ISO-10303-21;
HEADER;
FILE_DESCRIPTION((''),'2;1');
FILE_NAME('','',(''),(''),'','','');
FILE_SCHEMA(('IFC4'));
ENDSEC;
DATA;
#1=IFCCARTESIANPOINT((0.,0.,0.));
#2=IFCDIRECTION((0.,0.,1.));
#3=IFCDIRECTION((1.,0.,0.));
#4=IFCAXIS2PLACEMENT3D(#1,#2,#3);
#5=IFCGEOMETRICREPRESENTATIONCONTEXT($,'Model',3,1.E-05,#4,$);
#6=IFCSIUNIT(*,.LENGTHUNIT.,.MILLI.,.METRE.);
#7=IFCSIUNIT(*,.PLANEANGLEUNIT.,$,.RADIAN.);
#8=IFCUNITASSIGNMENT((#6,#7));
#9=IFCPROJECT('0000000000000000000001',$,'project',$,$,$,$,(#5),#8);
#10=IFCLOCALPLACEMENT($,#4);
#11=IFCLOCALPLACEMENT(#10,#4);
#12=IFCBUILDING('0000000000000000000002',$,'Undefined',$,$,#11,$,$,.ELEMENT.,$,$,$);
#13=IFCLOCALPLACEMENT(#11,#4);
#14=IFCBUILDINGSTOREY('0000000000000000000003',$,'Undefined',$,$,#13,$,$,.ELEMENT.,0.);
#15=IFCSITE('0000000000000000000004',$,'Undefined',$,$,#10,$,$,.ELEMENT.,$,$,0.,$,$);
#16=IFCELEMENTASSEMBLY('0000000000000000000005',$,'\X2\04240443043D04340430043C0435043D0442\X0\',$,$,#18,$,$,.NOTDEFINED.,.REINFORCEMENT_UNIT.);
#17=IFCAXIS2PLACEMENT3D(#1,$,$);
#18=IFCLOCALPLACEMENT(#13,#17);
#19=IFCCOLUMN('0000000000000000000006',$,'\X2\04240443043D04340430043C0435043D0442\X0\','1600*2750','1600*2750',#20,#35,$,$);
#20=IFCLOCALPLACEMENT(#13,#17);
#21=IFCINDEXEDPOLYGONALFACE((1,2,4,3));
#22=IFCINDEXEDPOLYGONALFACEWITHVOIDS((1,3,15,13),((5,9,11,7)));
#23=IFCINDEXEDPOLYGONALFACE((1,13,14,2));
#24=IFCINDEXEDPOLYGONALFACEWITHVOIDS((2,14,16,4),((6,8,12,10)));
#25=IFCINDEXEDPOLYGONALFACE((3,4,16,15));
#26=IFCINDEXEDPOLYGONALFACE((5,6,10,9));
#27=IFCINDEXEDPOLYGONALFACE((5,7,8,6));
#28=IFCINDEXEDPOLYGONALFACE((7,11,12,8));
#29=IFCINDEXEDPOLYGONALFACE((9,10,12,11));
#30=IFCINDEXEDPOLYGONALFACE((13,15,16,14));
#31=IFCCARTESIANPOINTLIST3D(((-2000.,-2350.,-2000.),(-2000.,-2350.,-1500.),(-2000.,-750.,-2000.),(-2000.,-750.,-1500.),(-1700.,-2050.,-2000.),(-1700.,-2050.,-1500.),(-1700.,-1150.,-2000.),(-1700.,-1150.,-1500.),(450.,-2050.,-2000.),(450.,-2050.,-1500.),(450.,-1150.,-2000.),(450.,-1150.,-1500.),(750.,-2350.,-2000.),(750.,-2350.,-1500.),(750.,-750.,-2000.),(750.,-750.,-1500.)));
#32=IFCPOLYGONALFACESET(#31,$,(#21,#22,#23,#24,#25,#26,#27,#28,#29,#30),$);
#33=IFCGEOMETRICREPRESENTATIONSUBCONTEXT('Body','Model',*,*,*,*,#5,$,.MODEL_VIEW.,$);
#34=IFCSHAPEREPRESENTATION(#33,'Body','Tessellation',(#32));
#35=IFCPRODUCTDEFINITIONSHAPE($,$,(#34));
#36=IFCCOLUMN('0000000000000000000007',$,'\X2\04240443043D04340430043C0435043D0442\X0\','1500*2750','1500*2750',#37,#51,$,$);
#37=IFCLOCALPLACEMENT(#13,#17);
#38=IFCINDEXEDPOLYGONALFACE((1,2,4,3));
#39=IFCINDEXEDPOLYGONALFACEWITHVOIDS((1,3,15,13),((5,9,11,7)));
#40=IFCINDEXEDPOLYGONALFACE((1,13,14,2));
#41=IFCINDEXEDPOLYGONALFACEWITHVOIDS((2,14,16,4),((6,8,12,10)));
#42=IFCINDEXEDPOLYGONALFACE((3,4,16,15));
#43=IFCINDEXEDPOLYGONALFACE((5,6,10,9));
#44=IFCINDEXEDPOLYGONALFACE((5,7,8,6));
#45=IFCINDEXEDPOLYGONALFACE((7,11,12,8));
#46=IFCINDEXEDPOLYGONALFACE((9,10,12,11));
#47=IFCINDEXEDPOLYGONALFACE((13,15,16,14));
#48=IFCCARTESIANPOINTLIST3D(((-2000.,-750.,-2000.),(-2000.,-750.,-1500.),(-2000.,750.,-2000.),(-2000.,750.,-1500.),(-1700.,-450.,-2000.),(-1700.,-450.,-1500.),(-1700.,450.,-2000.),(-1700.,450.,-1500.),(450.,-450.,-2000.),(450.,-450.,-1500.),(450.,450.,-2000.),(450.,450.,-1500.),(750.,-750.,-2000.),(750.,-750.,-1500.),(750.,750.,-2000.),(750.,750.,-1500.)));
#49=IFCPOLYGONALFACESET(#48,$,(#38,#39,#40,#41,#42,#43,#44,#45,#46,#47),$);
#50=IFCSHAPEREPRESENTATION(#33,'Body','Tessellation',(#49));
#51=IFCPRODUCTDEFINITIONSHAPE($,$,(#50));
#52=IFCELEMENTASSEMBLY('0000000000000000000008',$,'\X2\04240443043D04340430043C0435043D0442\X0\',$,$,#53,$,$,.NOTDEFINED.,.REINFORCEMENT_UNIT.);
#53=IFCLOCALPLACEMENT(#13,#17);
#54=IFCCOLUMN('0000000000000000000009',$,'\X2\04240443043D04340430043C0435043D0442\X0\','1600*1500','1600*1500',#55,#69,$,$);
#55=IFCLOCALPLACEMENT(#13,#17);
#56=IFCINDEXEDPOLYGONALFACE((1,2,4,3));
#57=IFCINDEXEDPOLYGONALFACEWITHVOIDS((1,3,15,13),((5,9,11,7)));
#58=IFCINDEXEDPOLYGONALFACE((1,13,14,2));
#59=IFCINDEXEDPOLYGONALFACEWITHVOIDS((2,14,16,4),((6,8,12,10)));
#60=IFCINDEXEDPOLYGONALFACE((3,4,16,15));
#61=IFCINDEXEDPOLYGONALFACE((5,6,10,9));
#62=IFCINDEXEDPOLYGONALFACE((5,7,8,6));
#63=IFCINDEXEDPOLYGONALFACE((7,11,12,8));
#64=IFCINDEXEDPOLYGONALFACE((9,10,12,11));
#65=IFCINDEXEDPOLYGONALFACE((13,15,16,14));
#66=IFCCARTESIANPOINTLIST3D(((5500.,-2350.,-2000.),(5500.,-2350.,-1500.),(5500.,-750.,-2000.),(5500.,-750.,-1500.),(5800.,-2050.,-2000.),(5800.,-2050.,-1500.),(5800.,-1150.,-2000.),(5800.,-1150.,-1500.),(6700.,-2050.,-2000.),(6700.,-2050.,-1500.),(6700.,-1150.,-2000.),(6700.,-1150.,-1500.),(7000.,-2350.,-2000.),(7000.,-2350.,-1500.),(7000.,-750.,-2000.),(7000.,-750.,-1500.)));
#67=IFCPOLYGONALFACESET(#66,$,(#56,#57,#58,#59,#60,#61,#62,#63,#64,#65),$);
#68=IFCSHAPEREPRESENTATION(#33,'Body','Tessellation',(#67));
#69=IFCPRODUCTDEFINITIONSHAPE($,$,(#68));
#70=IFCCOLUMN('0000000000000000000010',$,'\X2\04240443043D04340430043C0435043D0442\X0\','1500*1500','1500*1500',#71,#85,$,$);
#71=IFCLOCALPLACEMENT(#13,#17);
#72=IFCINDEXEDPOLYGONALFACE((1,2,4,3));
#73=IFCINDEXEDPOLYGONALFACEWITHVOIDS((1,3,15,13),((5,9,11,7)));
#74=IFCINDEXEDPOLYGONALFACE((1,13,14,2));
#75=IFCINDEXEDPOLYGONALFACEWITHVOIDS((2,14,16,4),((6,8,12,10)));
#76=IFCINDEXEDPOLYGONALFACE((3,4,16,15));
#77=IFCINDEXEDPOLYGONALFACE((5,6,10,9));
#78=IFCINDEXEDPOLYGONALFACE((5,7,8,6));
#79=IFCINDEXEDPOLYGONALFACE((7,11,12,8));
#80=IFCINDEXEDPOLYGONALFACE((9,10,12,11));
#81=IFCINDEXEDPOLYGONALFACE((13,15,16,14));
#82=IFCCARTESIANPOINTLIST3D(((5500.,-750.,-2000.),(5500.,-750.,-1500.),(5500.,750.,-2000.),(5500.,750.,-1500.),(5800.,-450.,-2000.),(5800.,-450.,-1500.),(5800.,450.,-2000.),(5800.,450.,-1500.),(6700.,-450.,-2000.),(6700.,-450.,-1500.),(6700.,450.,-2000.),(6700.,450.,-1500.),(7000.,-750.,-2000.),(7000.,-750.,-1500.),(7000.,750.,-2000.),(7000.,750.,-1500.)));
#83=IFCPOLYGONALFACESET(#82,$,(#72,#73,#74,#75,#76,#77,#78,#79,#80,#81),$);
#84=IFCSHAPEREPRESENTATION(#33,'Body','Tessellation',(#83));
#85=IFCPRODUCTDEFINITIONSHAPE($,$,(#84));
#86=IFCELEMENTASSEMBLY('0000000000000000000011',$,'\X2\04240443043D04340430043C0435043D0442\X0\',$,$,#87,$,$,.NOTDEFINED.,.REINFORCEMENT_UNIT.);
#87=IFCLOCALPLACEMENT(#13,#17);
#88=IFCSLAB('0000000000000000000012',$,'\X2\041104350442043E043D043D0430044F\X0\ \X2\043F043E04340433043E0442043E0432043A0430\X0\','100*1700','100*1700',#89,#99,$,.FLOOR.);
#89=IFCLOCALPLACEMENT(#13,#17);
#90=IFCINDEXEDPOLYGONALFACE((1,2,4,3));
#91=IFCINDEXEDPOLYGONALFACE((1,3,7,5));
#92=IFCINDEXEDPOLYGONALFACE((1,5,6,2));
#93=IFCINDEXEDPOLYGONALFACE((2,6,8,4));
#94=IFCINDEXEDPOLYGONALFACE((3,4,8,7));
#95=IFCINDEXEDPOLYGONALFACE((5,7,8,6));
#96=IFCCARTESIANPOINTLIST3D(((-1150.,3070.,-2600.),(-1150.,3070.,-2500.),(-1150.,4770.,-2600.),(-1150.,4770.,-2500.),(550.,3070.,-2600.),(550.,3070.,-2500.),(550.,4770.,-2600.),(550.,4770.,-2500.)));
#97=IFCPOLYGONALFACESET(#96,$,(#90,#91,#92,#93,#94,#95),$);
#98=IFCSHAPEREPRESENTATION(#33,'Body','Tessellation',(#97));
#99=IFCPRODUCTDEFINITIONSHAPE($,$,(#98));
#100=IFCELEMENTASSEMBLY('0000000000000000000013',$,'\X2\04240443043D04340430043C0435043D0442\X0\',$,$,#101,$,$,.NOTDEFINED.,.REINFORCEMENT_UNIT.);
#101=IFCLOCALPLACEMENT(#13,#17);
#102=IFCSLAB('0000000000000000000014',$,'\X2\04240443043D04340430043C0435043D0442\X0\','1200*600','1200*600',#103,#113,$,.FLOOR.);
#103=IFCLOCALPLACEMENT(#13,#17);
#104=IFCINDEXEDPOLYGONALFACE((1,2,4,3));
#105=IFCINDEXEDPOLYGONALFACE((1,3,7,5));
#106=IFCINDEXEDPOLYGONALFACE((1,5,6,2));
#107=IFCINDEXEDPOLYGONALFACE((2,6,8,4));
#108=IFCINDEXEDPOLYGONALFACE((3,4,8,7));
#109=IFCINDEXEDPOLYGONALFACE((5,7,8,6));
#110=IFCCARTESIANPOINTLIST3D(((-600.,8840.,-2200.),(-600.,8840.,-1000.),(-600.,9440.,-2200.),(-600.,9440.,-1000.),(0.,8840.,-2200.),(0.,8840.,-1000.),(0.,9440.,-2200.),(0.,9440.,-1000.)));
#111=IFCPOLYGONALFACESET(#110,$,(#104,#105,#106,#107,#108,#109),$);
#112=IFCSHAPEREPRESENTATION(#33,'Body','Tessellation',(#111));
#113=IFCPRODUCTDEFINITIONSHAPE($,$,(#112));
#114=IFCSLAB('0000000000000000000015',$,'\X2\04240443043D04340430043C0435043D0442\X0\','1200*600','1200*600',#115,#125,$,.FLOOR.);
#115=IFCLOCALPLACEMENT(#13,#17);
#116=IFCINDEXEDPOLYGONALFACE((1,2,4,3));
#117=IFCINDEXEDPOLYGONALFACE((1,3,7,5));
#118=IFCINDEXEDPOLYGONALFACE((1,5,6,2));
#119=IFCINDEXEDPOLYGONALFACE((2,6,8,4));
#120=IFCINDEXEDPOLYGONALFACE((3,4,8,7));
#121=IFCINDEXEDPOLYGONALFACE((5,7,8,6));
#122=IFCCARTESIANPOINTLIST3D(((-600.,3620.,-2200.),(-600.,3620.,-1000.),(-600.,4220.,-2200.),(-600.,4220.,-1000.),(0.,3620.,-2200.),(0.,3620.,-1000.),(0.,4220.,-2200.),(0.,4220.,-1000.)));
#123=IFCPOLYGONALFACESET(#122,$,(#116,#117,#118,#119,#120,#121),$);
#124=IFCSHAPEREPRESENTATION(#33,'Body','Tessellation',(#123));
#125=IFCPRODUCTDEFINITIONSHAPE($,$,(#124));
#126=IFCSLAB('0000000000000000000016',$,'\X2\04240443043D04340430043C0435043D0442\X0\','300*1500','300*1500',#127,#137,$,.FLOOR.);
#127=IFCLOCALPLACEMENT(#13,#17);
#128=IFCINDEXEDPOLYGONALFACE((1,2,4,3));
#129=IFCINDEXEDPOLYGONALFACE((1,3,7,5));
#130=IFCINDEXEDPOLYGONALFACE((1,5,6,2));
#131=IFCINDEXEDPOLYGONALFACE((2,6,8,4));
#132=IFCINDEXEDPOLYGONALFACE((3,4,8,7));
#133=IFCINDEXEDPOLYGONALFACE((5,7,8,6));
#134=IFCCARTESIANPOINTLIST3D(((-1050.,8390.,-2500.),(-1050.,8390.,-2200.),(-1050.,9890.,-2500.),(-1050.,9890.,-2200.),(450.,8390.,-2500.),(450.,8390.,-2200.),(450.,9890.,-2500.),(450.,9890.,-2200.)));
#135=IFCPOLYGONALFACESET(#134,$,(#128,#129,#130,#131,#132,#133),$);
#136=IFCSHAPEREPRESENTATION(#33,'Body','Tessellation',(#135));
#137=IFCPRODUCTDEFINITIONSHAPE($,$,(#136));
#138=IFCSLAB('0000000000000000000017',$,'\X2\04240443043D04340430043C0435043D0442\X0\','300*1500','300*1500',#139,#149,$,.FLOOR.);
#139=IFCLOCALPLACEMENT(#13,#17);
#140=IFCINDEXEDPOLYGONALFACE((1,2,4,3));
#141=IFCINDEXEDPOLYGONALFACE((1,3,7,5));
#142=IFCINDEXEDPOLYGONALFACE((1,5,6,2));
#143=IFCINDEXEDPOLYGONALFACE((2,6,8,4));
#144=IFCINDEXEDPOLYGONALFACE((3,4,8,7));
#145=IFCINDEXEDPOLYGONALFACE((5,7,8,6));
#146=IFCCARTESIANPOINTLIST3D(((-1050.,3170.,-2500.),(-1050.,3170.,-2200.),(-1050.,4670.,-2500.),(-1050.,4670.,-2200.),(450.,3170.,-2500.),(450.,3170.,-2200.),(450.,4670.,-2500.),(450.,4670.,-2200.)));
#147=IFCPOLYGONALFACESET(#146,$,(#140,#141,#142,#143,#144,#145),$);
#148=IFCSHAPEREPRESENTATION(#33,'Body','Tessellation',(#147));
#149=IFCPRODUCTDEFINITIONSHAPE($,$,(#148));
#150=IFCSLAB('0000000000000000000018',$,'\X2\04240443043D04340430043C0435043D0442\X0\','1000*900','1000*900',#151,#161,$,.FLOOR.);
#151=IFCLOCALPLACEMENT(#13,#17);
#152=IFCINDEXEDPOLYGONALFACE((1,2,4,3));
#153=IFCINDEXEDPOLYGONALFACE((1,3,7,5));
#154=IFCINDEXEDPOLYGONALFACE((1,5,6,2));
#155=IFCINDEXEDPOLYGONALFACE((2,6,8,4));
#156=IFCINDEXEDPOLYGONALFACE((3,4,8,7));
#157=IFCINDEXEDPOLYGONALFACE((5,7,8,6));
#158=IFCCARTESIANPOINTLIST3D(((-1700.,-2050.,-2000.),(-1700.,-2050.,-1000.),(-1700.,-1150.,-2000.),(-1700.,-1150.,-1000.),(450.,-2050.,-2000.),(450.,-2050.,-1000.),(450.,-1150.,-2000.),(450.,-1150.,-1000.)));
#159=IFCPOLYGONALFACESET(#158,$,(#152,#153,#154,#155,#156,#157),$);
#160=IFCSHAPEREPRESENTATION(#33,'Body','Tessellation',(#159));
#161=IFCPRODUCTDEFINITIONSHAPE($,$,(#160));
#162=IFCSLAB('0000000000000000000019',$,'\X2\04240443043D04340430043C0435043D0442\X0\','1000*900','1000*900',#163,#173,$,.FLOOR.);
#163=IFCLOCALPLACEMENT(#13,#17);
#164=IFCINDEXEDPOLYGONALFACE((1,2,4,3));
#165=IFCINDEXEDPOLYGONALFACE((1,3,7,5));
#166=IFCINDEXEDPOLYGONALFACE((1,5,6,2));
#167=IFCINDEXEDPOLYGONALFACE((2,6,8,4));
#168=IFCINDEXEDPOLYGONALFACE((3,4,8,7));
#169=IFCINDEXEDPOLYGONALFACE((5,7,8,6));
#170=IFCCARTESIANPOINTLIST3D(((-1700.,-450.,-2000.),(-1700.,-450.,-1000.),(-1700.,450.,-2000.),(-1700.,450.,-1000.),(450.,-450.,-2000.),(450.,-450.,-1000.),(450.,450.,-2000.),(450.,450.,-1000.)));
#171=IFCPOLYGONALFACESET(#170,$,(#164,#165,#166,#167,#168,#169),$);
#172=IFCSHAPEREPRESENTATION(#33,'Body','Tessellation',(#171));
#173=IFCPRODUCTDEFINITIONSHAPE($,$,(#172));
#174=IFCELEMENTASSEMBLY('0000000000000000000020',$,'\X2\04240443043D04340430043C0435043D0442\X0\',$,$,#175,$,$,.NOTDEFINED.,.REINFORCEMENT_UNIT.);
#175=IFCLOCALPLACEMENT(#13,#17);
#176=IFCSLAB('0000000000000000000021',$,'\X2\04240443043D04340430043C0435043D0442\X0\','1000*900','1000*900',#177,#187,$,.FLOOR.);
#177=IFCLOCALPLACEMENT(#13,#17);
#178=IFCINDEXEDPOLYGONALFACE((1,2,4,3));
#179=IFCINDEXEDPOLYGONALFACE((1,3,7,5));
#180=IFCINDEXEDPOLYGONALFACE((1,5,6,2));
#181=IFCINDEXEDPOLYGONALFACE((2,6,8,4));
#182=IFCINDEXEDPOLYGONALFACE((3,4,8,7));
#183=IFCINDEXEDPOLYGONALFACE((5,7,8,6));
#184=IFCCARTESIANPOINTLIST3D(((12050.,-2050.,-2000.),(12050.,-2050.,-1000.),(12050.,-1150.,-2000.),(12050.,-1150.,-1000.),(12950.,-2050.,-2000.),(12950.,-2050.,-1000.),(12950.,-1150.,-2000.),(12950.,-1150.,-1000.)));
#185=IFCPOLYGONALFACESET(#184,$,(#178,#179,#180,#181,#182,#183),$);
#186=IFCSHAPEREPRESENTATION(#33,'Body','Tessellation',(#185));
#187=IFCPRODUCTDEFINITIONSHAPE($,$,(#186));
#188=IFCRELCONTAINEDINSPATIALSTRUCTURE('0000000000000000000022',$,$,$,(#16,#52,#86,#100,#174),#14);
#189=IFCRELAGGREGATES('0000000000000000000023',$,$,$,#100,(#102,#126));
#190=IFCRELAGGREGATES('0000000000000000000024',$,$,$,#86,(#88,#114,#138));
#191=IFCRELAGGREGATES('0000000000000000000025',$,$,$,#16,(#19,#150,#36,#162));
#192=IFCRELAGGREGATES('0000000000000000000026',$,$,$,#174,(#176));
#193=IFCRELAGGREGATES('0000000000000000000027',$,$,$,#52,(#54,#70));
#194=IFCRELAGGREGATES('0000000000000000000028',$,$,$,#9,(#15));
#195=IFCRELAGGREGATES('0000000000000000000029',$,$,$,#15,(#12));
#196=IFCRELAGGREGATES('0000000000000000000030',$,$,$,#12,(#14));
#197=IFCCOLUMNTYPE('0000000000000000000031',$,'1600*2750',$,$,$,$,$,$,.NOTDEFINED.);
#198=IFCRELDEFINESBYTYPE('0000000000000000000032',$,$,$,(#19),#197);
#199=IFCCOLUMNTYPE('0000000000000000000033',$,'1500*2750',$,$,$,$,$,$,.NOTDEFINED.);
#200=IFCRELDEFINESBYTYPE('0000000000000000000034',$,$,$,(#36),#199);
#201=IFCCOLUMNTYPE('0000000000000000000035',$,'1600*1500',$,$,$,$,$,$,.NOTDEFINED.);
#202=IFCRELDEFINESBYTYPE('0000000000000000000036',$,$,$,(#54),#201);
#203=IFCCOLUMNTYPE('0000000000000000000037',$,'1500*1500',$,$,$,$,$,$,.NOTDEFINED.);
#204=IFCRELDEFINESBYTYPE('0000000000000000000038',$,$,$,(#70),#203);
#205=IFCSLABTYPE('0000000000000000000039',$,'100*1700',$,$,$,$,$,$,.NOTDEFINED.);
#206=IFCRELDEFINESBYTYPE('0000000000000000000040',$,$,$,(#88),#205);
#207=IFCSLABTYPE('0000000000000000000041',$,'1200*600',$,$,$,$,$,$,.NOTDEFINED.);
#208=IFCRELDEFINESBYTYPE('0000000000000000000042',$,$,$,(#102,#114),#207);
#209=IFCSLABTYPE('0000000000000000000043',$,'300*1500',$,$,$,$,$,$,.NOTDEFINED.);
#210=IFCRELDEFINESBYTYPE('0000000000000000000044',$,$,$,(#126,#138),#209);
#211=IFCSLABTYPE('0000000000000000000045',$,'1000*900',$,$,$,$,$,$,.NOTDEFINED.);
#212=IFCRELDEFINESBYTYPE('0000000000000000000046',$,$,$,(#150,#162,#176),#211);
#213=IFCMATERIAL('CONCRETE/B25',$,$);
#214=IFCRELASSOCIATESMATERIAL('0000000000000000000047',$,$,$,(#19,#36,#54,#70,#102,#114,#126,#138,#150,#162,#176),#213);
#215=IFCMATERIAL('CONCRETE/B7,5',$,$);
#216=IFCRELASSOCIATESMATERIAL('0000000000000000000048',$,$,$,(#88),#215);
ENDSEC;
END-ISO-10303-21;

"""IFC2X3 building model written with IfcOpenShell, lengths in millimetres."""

from ifc_helpers import new_model, si_unit, frame, origin_with_axes, origin_2d_with_axis, place, context, subcontext, project, spatial, polyline, rectangle, outline, extrude, boolean, material, type_object, element, aggregate, save


model = new_model("IFC2X3")

# Units and contexts
model_context = context("Model", 3, precision=1e-05, world=origin_with_axes())
body_context = subcontext(model_context, "Body", "Model", "MODEL_VIEW")
ifc_project = project(units=[si_unit("LENGTHUNIT", "METRE", prefix="MILLI"), si_unit("PLANEANGLEUNIT", "RADIAN")], contexts=[model_context])

# Site, building, storey
site_placement = place(None, origin_with_axes())
site = spatial("IfcSite", under=ifc_project, at=site_placement, Name="Undefined", CompositionType="ELEMENT", RefElevation=0.0)
building_placement = place(site_placement, origin_with_axes())
building = spatial("IfcBuilding", under=site, at=building_placement, Name="Undefined", CompositionType="ELEMENT")
storey_placement = place(building_placement, origin_with_axes())
storey = spatial("IfcBuildingStorey", under=building, at=storey_placement, Name="Undefined", CompositionType="ELEMENT", Elevation=0.0)

# Element assemblies, columns
assembly_1_placement = place(storey_placement, origin_with_axes())
assembly_1 = element("IfcElementAssembly", 1, at=assembly_1_placement, inside=storey, Name="Фундамент", AssemblyPlace="NOTDEFINED", PredefinedType="REINFORCEMENT_UNIT")
ifc_material_1 = material(Name="CONCRETE/B25")
column_type_1 = type_object("IfcColumnType", Name="1600*2750", PredefinedType="NOTDEFINED")
column_1_placement = place(assembly_1_placement, frame((-625.0, -1550.0, -2000.0), z_axis=(0.0, 0.0, 1.0), x_axis=(0.0, -1.0, 0.0)))
column_1 = element("IfcColumn", 2, at=column_1_placement, type_object=column_type_1, material=ifc_material_1, Name="Фундамент", Description="1600*2750", ObjectType="1600*2750", context=body_context, shape_type="CSG", body=[
    boolean("DIFFERENCE", extrude(rectangle(XDim=2750.0, YDim=1600.0, at=origin_2d_with_axis()), frame((0.0, 0.0, 500.0), z_axis=(0.0, 0.0, -1.0), x_axis=(0.0, 1.0, 0.0)), (0.0, 0.0, 1.0), 500.0), extrude(outline(polyline([(0.0, 0.0), (900.0, 0.0), (900.0, 2150.0), (0.0, 2150.0), (0.0, 0.0)])), frame((-400.0, -1075.0, -100.0), z_axis=(0.0, 0.0, 1.0), x_axis=(1.0, 0.0, 0.0)), (0.0, 0.0, 1.0), 700.0)),
])
column_type_2 = type_object("IfcColumnType", Name="1500*2750", PredefinedType="NOTDEFINED")
column_2_placement = place(assembly_1_placement, frame((-625.0, 0.0, -2000.0), z_axis=(0.0, 0.0, 1.0), x_axis=(0.0, -1.0, 0.0)))
column_2 = element("IfcColumn", 3, at=column_2_placement, type_object=column_type_2, material=ifc_material_1, Name="Фундамент", Description="1500*2750", ObjectType="1500*2750", context=body_context, shape_type="CSG", body=[
    boolean("DIFFERENCE", extrude(rectangle(XDim=2750.0, YDim=1500.0, at=origin_2d_with_axis()), frame((0.0, 0.0, 500.0), z_axis=(0.0, 0.0, -1.0), x_axis=(0.0, 1.0, 0.0)), (0.0, 0.0, 1.0), 500.0), extrude(outline(polyline([(0.0, 0.0), (900.0, 0.0), (900.0, 2150.0), (0.0, 2150.0), (0.0, 0.0)])), frame((-450.0, -1075.0, -100.0), z_axis=(0.0, 0.0, 1.0), x_axis=(1.0, 0.0, 0.0)), (0.0, 0.0, 1.0), 700.0)),
])
assembly_2_placement = place(storey_placement, origin_with_axes())
assembly_2 = element("IfcElementAssembly", 4, at=assembly_2_placement, inside=storey, Name="Фундамент", AssemblyPlace="NOTDEFINED", PredefinedType="REINFORCEMENT_UNIT")
column_type_3 = type_object("IfcColumnType", Name="1600*1500", PredefinedType="NOTDEFINED")
column_3_placement = place(assembly_2_placement, frame((6250.0, -1550.0, -2000.0), z_axis=(0.0, 0.0, 1.0), x_axis=(0.0, -1.0, 0.0)))
column_3 = element("IfcColumn", 5, at=column_3_placement, type_object=column_type_3, material=ifc_material_1, Name="Фундамент", Description="1600*1500", ObjectType="1600*1500", context=body_context, shape_type="CSG", body=[
    boolean("DIFFERENCE", extrude(rectangle(XDim=1500.0, YDim=1600.0, at=origin_2d_with_axis()), frame((0.0, 0.0, 500.0), z_axis=(0.0, 0.0, -1.0), x_axis=(0.0, 1.0, 0.0)), (0.0, 0.0, 1.0), 500.0), extrude(outline(polyline([(0.0, 0.0), (900.0, 0.0), (900.0, 900.0), (0.0, 900.0), (0.0, 0.0)])), frame((-400.0, -450.0, -100.0), z_axis=(0.0, 0.0, 1.0), x_axis=(1.0, 0.0, 0.0)), (0.0, 0.0, 1.0), 700.0)),
])
column_type_4 = type_object("IfcColumnType", Name="1500*1500", PredefinedType="NOTDEFINED")
column_4_placement = place(assembly_2_placement, frame((6250.0, 0.0, -2000.0), z_axis=(0.0, 0.0, 1.0), x_axis=(0.0, -1.0, 0.0)))
column_4 = element("IfcColumn", 6, at=column_4_placement, type_object=column_type_4, material=ifc_material_1, Name="Фундамент", Description="1500*1500", ObjectType="1500*1500", context=body_context, shape_type="CSG", body=[
    boolean("DIFFERENCE", extrude(rectangle(XDim=1500.0, YDim=1500.0, at=origin_2d_with_axis()), frame((0.0, 0.0, 500.0), z_axis=(0.0, 0.0, -1.0), x_axis=(0.0, 1.0, 0.0)), (0.0, 0.0, 1.0), 500.0), extrude(outline(polyline([(0.0, 0.0), (900.0, 0.0), (900.0, 900.0), (0.0, 900.0), (0.0, 0.0)])), frame((-450.0, -450.0, -100.0), z_axis=(0.0, 0.0, 1.0), x_axis=(1.0, 0.0, 0.0)), (0.0, 0.0, 1.0), 700.0)),
])

# Element assemblies, slabs
assembly_3_placement = place(storey_placement, origin_with_axes())
assembly_3 = element("IfcElementAssembly", 7, at=assembly_3_placement, inside=storey, Name="Фундамент", AssemblyPlace="NOTDEFINED", PredefinedType="REINFORCEMENT_UNIT")
ifc_material_2 = material(Name="CONCRETE/B7,5")
slab_type_1 = type_object("IfcSlabType", Name="100*1700", PredefinedType="NOTDEFINED")
slab_1_placement = place(assembly_3_placement, frame((-1150.0, 4770.0, -2550.0), z_axis=(0.0, 0.0, 1.0), x_axis=(0.0, -1.0, 0.0)))
slab_1 = element("IfcSlab", 8, at=slab_1_placement, type_object=slab_type_1, material=ifc_material_2, Name="Бетонная подготовка", Description="100*1700", ObjectType="100*1700", PredefinedType="FLOOR", context=body_context, shape_type="SweptSolid", body=[
    extrude(outline(polyline([(0.0, 0.0), (1700.0, 0.0), (1700.0, 1700.0), (0.0, 1700.0), (0.0, 0.0)])), frame((0.0, 0.0, -50.0), z_axis=(0.0, 0.0, 1.0), x_axis=(1.0, 0.0, 0.0)), (0.0, 0.0, 1.0), 100.0),
])
assembly_4_placement = place(storey_placement, origin_with_axes())
assembly_4 = element("IfcElementAssembly", 9, at=assembly_4_placement, inside=storey, Name="Фундамент", AssemblyPlace="NOTDEFINED", PredefinedType="REINFORCEMENT_UNIT")
slab_type_2 = type_object("IfcSlabType", Name="1200*600", PredefinedType="NOTDEFINED")
slab_2_placement = place(assembly_4_placement, frame((-600.0, 9440.0, -1600.0), z_axis=(0.0, 0.0, 1.0), x_axis=(0.0, -1.0, 0.0)))
slab_2 = element("IfcSlab", 10, at=slab_2_placement, type_object=slab_type_2, material=ifc_material_1, Name="Фундамент", Description="1200*600", ObjectType="1200*600", PredefinedType="FLOOR", context=body_context, shape_type="SweptSolid", body=[
    extrude(outline(polyline([(0.0, 0.0), (600.0, 0.0), (600.0, 600.0), (0.0, 600.0), (0.0, 0.0)])), frame((0.0, 0.0, -600.0), z_axis=(0.0, 0.0, 1.0), x_axis=(1.0, 0.0, 0.0)), (0.0, 0.0, 1.0), 1200.0),
])

# Slabs
slab_3_placement = place(assembly_3_placement, frame((-600.0, 4220.0, -1600.0), z_axis=(0.0, 0.0, 1.0), x_axis=(0.0, -1.0, 0.0)))
slab_3 = element("IfcSlab", 11, at=slab_3_placement, type_object=slab_type_2, material=ifc_material_1, Name="Фундамент", Description="1200*600", ObjectType="1200*600", PredefinedType="FLOOR", context=body_context, shape_type="SweptSolid", body=[
    extrude(outline(polyline([(0.0, 0.0), (600.0, 0.0), (600.0, 600.0), (0.0, 600.0), (0.0, 0.0)])), frame((0.0, 0.0, -600.0), z_axis=(0.0, 0.0, 1.0), x_axis=(1.0, 0.0, 0.0)), (0.0, 0.0, 1.0), 1200.0),
])
slab_type_3 = type_object("IfcSlabType", Name="300*1500", PredefinedType="NOTDEFINED")
slab_4_placement = place(assembly_4_placement, frame((-1050.0, 9890.0, -2350.0), z_axis=(0.0, 0.0, 1.0), x_axis=(0.0, -1.0, 0.0)))
slab_4 = element("IfcSlab", 12, at=slab_4_placement, type_object=slab_type_3, material=ifc_material_1, Name="Фундамент", Description="300*1500", ObjectType="300*1500", PredefinedType="FLOOR", context=body_context, shape_type="SweptSolid", body=[
    extrude(outline(polyline([(0.0, 0.0), (1500.0, 0.0), (1500.0, 1500.0), (0.0, 1500.0), (0.0, 0.0)])), frame((0.0, 0.0, -150.0), z_axis=(0.0, 0.0, 1.0), x_axis=(1.0, 0.0, 0.0)), (0.0, 0.0, 1.0), 300.0),
])
aggregate(assembly_4, [slab_2, slab_4])
slab_5_placement = place(assembly_3_placement, frame((-1050.0, 4670.0, -2350.0), z_axis=(0.0, 0.0, 1.0), x_axis=(0.0, -1.0, 0.0)))
slab_5 = element("IfcSlab", 13, at=slab_5_placement, type_object=slab_type_3, material=ifc_material_1, Name="Фундамент", Description="300*1500", ObjectType="300*1500", PredefinedType="FLOOR", context=body_context, shape_type="SweptSolid", body=[
    extrude(outline(polyline([(0.0, 0.0), (1500.0, 0.0), (1500.0, 1500.0), (0.0, 1500.0), (0.0, 0.0)])), frame((0.0, 0.0, -150.0), z_axis=(0.0, 0.0, 1.0), x_axis=(1.0, 0.0, 0.0)), (0.0, 0.0, 1.0), 300.0),
])
aggregate(assembly_3, [slab_1, slab_3, slab_5])
slab_type_4 = type_object("IfcSlabType", Name="1000*900", PredefinedType="NOTDEFINED")
slab_6_placement = place(assembly_1_placement, frame((-1700.0, -1150.0, -1500.0), z_axis=(0.0, 0.0, 1.0), x_axis=(0.0, -1.0, 0.0)))
slab_6 = element("IfcSlab", 14, at=slab_6_placement, type_object=slab_type_4, material=ifc_material_1, Name="Фундамент", Description="1000*900", ObjectType="1000*900", PredefinedType="FLOOR", context=body_context, shape_type="SweptSolid", body=[
    extrude(outline(polyline([(0.0, 0.0), (900.0, 0.0), (900.0, 2150.0), (0.0, 2150.0), (0.0, 0.0)])), frame((0.0, 0.0, -500.0), z_axis=(0.0, 0.0, 1.0), x_axis=(1.0, 0.0, 0.0)), (0.0, 0.0, 1.0), 1000.0),
])
slab_7_placement = place(assembly_1_placement, frame((-1700.0, 450.0, -1500.0), z_axis=(0.0, 0.0, 1.0), x_axis=(0.0, -1.0, 0.0)))
slab_7 = element("IfcSlab", 15, at=slab_7_placement, type_object=slab_type_4, material=ifc_material_1, Name="Фундамент", Description="1000*900", ObjectType="1000*900", PredefinedType="FLOOR", context=body_context, shape_type="SweptSolid", body=[
    extrude(outline(polyline([(0.0, 0.0), (900.0, 0.0), (900.0, 2150.0), (0.0, 2150.0), (0.0, 0.0)])), frame((0.0, 0.0, -500.0), z_axis=(0.0, 0.0, 1.0), x_axis=(1.0, 0.0, 0.0)), (0.0, 0.0, 1.0), 1000.0),
])

# Element assembly, slab
assembly_5_placement = place(storey_placement, origin_with_axes())
assembly_5 = element("IfcElementAssembly", 16, at=assembly_5_placement, inside=storey, Name="Фундамент", AssemblyPlace="NOTDEFINED", PredefinedType="REINFORCEMENT_UNIT")
slab_8_placement = place(assembly_5_placement, frame((12050.0, -1150.0, -1500.0), z_axis=(0.0, 0.0, 1.0), x_axis=(0.0, -1.0, 0.0)))
slab_8 = element("IfcSlab", 17, at=slab_8_placement, type_object=slab_type_4, material=ifc_material_1, Name="Фундамент", Description="1000*900", ObjectType="1000*900", PredefinedType="FLOOR", context=body_context, shape_type="SweptSolid", body=[
    extrude(outline(polyline([(0.0, 0.0), (900.0, 0.0), (900.0, 900.0), (0.0, 900.0), (0.0, 0.0)])), frame((0.0, 0.0, -500.0), z_axis=(0.0, 0.0, 1.0), x_axis=(1.0, 0.0, 0.0)), (0.0, 0.0, 1.0), 1000.0),
])

aggregate(assembly_1, [column_1, slab_6, column_2, slab_7])
aggregate(assembly_5, [slab_8])
aggregate(assembly_2, [column_3, column_4])

save(model, "model.ifc")
